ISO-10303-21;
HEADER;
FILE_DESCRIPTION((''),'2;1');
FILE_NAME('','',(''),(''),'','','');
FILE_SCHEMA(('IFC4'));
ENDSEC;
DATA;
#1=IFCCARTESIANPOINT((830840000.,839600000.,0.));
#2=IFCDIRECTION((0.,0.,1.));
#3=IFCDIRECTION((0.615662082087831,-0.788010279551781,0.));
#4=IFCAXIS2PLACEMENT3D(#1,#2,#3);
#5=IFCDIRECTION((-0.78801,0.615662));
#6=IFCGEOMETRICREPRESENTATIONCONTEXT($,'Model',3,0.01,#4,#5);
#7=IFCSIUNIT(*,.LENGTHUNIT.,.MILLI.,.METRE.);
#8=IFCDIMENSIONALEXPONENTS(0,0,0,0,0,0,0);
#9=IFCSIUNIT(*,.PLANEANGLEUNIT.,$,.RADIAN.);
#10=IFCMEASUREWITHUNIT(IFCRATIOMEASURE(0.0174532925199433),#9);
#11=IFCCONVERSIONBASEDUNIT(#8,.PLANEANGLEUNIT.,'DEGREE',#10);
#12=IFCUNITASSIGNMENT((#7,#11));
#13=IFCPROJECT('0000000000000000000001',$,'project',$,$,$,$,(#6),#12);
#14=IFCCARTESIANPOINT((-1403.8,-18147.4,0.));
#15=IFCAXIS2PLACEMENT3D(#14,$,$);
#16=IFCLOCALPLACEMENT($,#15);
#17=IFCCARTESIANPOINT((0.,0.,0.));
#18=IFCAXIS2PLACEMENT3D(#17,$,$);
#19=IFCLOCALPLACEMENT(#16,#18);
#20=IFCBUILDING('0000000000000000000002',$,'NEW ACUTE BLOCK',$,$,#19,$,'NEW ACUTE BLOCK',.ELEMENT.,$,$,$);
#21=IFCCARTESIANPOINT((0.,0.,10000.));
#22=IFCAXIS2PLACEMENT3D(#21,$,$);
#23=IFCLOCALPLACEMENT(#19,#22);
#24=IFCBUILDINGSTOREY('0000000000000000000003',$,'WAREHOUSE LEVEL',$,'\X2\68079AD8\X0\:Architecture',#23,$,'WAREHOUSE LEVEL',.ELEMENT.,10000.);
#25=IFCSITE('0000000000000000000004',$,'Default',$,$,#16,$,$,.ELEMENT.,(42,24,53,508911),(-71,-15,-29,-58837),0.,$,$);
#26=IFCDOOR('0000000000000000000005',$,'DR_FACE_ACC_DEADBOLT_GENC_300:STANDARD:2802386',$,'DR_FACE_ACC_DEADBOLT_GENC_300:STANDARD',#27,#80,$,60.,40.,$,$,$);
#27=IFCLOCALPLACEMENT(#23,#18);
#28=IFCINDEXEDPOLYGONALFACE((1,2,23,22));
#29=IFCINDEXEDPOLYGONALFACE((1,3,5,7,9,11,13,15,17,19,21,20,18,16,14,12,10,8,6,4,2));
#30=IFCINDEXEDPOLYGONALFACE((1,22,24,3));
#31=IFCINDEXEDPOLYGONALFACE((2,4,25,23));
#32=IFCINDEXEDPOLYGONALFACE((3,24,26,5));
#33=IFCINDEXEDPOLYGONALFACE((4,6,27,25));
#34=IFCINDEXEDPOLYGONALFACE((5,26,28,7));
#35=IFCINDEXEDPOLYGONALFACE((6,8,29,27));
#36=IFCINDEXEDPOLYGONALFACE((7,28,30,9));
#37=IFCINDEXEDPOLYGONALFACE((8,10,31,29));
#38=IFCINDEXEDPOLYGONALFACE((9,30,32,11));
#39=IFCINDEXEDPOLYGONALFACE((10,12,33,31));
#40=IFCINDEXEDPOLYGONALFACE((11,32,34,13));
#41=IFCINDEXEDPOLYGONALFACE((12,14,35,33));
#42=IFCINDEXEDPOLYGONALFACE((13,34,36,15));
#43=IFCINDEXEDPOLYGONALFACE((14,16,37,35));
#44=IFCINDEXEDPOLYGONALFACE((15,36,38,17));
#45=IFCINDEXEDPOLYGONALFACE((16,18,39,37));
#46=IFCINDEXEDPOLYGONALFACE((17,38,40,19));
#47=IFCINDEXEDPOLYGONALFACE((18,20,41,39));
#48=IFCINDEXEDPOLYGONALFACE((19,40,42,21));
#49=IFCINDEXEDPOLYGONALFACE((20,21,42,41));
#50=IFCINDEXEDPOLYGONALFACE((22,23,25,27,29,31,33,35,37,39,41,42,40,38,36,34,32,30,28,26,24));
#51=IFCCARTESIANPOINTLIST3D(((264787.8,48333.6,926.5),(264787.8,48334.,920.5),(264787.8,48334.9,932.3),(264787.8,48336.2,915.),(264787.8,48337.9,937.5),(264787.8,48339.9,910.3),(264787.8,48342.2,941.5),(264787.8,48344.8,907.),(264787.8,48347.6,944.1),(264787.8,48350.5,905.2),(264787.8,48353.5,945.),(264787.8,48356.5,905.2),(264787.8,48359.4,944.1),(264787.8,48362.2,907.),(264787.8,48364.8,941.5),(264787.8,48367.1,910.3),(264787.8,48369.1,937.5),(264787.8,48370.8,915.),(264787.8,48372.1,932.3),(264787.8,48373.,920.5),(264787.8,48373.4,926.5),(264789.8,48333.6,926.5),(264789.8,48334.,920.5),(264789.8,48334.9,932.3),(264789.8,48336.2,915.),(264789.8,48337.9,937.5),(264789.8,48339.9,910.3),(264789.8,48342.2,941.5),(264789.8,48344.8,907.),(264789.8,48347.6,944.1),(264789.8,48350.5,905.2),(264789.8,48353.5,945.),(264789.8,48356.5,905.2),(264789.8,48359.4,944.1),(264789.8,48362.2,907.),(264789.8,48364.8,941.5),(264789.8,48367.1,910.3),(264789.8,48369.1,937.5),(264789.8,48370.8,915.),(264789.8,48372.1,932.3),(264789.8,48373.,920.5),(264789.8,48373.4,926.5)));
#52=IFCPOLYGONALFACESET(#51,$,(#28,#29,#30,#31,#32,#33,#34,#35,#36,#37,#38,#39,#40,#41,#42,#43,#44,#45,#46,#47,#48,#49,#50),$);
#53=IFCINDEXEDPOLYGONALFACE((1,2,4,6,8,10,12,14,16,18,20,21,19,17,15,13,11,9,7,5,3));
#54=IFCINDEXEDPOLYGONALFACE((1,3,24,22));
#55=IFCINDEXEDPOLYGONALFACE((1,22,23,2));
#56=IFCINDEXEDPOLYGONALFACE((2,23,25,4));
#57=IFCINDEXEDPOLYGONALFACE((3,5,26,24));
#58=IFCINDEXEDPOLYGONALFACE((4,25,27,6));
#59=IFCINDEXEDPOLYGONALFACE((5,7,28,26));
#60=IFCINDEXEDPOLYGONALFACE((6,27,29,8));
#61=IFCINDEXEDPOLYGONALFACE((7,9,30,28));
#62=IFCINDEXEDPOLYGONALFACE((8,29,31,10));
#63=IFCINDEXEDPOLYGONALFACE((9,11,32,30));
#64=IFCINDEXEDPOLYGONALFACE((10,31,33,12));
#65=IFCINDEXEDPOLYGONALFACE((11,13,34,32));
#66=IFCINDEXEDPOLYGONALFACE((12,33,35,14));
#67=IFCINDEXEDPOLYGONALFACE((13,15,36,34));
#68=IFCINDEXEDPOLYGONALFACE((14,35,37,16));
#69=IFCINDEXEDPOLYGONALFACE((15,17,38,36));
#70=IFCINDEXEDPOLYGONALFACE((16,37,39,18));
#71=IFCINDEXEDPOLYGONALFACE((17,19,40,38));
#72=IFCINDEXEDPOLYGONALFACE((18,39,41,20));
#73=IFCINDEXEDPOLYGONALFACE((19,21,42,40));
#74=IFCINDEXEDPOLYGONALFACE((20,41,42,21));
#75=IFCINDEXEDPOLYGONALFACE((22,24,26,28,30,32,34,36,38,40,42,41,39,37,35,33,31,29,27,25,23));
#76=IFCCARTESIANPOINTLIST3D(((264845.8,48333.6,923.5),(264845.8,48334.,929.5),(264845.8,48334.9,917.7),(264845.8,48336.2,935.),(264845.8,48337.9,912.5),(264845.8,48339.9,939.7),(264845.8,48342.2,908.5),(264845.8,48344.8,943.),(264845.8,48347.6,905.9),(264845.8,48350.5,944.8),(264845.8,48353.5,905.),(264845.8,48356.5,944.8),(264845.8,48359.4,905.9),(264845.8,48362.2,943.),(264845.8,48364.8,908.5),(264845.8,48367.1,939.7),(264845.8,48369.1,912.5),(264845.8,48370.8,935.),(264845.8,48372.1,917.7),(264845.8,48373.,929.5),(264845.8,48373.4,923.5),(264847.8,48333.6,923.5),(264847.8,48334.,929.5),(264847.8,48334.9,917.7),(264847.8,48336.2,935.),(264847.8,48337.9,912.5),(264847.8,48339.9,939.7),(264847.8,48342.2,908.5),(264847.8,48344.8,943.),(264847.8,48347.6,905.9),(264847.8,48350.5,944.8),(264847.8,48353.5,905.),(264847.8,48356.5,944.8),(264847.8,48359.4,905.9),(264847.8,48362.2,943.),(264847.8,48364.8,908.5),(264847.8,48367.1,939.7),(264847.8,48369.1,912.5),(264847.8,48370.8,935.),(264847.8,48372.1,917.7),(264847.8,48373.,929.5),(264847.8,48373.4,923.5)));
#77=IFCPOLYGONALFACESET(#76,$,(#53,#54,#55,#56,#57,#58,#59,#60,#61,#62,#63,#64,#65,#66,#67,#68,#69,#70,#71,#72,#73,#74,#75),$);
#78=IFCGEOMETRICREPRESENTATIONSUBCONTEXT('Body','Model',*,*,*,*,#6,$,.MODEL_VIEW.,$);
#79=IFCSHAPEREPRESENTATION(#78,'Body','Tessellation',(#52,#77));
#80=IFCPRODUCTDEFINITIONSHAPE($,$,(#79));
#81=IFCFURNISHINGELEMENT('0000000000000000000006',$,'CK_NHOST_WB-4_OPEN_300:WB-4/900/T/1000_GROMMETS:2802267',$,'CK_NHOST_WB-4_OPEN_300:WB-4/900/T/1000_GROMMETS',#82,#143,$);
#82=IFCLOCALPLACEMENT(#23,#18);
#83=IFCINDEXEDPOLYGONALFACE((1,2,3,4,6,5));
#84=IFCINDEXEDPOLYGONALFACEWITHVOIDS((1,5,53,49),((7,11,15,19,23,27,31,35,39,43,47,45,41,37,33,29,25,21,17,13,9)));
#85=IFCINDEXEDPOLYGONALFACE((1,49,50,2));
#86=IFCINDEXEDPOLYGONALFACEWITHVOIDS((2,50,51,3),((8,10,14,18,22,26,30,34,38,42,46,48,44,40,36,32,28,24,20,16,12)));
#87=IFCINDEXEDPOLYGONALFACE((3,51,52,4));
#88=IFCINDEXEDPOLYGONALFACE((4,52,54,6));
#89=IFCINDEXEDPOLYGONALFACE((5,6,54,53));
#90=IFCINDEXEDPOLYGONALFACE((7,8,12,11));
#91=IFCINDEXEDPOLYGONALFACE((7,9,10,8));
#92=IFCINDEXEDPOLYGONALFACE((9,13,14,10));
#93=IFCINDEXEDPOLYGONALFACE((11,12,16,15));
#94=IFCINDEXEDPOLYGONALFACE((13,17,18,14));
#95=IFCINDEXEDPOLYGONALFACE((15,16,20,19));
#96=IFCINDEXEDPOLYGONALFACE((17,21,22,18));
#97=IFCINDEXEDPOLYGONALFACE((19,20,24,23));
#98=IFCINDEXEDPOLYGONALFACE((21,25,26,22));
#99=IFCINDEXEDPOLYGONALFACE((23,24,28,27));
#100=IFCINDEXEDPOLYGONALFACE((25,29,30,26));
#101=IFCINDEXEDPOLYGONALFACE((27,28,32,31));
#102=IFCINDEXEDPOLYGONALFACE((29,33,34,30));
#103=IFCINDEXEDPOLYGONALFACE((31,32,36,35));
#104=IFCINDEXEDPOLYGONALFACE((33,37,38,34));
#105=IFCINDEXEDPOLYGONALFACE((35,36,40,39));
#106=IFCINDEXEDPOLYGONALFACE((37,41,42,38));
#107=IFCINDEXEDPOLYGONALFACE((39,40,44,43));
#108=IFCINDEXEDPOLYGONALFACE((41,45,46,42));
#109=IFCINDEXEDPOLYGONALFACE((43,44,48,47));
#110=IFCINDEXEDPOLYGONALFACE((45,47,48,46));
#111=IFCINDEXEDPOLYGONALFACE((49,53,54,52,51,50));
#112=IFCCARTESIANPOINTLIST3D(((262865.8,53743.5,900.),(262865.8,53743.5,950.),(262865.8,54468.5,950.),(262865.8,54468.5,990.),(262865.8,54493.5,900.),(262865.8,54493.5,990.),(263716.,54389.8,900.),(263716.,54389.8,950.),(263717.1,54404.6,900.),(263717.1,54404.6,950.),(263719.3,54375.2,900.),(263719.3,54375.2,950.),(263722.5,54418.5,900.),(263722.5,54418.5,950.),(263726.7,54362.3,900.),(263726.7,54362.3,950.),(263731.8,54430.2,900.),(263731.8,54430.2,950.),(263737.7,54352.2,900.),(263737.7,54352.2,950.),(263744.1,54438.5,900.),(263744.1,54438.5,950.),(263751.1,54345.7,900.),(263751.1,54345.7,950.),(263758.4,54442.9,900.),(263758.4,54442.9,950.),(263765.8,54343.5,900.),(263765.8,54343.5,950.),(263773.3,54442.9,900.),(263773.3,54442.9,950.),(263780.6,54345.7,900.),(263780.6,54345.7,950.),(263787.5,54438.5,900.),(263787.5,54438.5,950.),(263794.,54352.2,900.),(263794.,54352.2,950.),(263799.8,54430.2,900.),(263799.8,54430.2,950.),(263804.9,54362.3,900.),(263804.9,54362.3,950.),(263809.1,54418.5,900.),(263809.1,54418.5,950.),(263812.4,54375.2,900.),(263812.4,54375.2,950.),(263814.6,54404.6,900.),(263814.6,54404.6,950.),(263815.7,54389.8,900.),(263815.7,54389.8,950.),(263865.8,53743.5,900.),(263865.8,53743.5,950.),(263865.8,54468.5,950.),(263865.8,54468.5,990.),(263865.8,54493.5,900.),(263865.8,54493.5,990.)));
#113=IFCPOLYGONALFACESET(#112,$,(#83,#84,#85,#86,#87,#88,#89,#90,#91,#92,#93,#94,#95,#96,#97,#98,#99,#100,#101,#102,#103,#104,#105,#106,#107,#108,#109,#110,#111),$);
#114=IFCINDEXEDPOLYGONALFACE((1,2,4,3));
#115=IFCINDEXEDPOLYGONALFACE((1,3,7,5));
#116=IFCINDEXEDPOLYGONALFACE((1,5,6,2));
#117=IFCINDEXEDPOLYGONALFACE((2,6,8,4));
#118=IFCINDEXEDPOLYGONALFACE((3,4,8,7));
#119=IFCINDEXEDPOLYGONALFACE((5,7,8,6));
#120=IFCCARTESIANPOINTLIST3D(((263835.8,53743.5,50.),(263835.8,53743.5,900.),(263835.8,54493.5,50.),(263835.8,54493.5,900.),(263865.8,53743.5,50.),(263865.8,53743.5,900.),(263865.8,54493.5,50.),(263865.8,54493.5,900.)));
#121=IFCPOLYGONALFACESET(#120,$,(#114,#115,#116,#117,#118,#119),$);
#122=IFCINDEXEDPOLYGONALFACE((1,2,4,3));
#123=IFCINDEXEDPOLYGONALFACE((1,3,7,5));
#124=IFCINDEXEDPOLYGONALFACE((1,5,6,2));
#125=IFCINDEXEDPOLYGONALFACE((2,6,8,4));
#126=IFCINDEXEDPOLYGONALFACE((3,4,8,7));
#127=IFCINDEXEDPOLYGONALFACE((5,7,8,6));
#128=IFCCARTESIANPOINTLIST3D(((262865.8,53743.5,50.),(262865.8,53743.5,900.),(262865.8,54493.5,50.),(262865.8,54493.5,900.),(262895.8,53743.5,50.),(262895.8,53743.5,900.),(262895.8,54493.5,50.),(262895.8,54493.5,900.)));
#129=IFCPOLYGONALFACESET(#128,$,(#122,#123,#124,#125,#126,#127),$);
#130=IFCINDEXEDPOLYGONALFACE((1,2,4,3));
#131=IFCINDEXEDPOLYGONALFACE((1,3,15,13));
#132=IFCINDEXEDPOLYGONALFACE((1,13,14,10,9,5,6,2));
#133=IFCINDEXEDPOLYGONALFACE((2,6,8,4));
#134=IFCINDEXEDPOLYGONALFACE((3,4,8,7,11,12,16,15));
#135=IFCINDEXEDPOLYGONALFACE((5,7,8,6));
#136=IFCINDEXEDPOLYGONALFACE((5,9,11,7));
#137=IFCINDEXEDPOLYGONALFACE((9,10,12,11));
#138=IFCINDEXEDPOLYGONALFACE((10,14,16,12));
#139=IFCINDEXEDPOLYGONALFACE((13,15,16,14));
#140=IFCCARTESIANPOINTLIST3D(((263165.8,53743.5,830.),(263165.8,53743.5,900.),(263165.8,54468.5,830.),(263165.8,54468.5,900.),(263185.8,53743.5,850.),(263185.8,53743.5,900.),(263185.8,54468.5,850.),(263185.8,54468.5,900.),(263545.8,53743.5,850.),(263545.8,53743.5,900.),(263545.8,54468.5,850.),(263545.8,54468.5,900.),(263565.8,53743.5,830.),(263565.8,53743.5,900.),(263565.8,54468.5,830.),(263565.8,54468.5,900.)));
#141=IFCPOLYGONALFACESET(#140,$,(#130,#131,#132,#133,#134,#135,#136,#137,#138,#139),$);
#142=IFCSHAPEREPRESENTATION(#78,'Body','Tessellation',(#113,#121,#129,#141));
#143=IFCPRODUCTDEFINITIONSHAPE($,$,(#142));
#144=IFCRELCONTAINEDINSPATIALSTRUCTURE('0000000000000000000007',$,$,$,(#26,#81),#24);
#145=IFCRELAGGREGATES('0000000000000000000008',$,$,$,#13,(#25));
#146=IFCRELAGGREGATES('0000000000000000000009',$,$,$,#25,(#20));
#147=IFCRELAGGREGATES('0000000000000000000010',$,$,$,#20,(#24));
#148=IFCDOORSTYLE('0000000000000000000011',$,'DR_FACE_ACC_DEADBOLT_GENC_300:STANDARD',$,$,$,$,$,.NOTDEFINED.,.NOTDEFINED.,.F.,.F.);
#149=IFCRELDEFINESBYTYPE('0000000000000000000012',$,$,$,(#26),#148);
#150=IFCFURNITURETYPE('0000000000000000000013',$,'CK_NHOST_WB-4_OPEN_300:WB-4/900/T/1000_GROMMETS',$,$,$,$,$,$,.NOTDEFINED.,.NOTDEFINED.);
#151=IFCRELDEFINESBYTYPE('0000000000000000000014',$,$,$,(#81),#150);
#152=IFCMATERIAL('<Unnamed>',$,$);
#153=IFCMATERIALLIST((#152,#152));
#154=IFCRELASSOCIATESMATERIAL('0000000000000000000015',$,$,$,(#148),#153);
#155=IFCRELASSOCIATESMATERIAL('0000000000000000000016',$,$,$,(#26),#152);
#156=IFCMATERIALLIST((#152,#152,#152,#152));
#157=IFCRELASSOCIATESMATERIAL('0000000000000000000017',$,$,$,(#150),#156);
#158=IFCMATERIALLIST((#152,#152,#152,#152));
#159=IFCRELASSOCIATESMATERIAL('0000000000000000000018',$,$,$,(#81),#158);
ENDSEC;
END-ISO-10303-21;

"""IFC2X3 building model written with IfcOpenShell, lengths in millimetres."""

from ifc_helpers import new_model, entity, si_unit, converted_unit, direction, frame, frame_2d, origin, place, context, subcontext, project, spatial, polyline, rectangle, circle, outline, extrude, source, transform, mapped, material, material_list, type_object, type_shapes, element, save


model = new_model("IFC2X3")

# Units and contexts
model_context = context("Model", 3, precision=0.01, world=frame((830840000.0, 839600000.0, 0.0), z_axis=(0.0, 0.0, 1.0), x_axis=(0.615662082087831, -0.788010279551781, 0.0)), true_north=direction((-0.78801, 0.615662)))
body_context = subcontext(model_context, "Body", "Model", "MODEL_VIEW")
ifc_project = project(units=[si_unit("LENGTHUNIT", "METRE", prefix="MILLI"), converted_unit("PLANEANGLEUNIT", "DEGREE", entity("IfcRatioMeasure", 0.0174532925199433), si_unit("PLANEANGLEUNIT", "RADIAN"), dimensions=[0, 0, 0, 0, 0, 0, 0])], contexts=[model_context])

# Site, building, storey
site_placement = place(None, frame((-1403.8, -18147.4, 0.0)))
site = spatial("IfcSite", under=ifc_project, at=site_placement, Name="Default", CompositionType="ELEMENT", RefLatitude=(42, 24, 53, 508911), RefLongitude=(-71, -15, -29, -58837), RefElevation=0.0)
building_placement = place(site_placement, origin())
building = spatial("IfcBuilding", under=site, at=building_placement, Name="NEW ACUTE BLOCK", LongName="NEW ACUTE BLOCK", CompositionType="ELEMENT")
storey_placement = place(building_placement, frame((0.0, 0.0, 10000.0)))
storey = spatial("IfcBuildingStorey", under=building, at=storey_placement, Name="WAREHOUSE LEVEL", ObjectType="标高:Architecture", LongName="WAREHOUSE LEVEL", CompositionType="ELEMENT", Elevation=10000.0)

# Door
ifc_material_1 = material(Name="<Unnamed>")
ifc_material_list_1 = material_list([ifc_material_1, ifc_material_1])
door_style_1 = type_object("IfcDoorStyle", Name="DR_FACE_ACC_DEADBOLT_GENC_300:STANDARD", ConstructionType="NOTDEFINED", OperationType="NOTDEFINED", ParameterTakesPrecedence=False, Sizeable=False, material=ifc_material_list_1)
shared_shape_1 = source(origin(), body_context, "Body", "SweptSolid", [
    extrude(circle(Radius=20.0, at=frame_2d((0.0, 0.0), x_axis=(1.0, 0.0))), frame((0.0, 0.0, -58.0), z_axis=(0.0, 0.0, 1.0), x_axis=(-1.0, 0.0, 0.0)), (0.0, 0.0, 1.0), 2.0),
    extrude(circle(Radius=20.0, at=frame_2d((0.0, 0.0), x_axis=(1.0, 0.0))), origin(), (0.0, 0.0, 1.0), 2.0),
])
type_shapes(door_style_1, [shared_shape_1])
door_1_placement = place(storey_placement, frame((264845.8, 48353.5, 925.0), z_axis=(1.0, 0.0, 0.0), x_axis=(0.0, 0.0, -1.0)))
element("IfcDoor", 1, at=door_1_placement, inside=storey, type_object=door_style_1, material=ifc_material_1, Name="DR_FACE_ACC_DEADBOLT_GENC_300:STANDARD:2802386", ObjectType="DR_FACE_ACC_DEADBOLT_GENC_300:STANDARD", OverallHeight=60.0, OverallWidth=40.0, context=body_context, shape_type="MappedRepresentation", body=[
    mapped(shared_shape_1, transform((0.0, 0.0, 0.0), scale=1.0)),
])

# Furnishing element, opening
ifc_material_list_2 = material_list([ifc_material_1, ifc_material_1, ifc_material_1, ifc_material_1])
ifc_material_list_3 = material_list([ifc_material_1, ifc_material_1, ifc_material_1, ifc_material_1])
furniture_type_1 = type_object("IfcFurnitureType", Name="CK_NHOST_WB-4_OPEN_300:WB-4/900/T/1000_GROMMETS", material=ifc_material_list_3)
shared_shape_2 = source(origin(), body_context, "Body", "SweptSolid", [
    extrude(outline(polyline([(-46.7, -258.3), (43.3, -258.3), (43.3, -233.3), (3.3, -233.3), (3.3, 491.7), (-46.7, 491.7), (-46.7, -258.3)])), frame((-500.0, 116.7, 896.7), z_axis=(1.0, 0.0, 0.0), x_axis=(0.0, 0.0, 1.0)), (0.0, 0.0, 1.0), 1000.0),
    extrude(rectangle(XDim=750.0, YDim=30.0, at=frame_2d((0.0, 0.0), x_axis=(1.0, 0.0))), frame((485.0, 0.0, 0.0), z_axis=(0.0, 0.0, 1.0), x_axis=(0.0, -1.0, 0.0)), (0.0, 0.0, 1.0), 850.0),
    extrude(rectangle(XDim=30.0, YDim=750.0, at=frame_2d((0.0, 0.0), x_axis=(1.0, 0.0))), frame((-485.0, 0.0, 0.0), z_axis=(0.0, 0.0, 1.0), x_axis=(-1.0, 0.0, 0.0)), (0.0, 0.0, 1.0), 850.0),
    extrude(outline(polyline([(-40.0, -200.0), (30.0, -200.0), (30.0, -180.0), (-20.0, -180.0), (-20.0, 180.0), (30.0, 180.0), (30.0, 200.0), (-40.0, 200.0), (-40.0, -200.0)])), frame((0.0, -375.0, 820.0), z_axis=(0.0, 1.0, 0.0), x_axis=(0.0, 0.0, 1.0)), (0.0, 0.0, 1.0), 725.0),
])
type_shapes(furniture_type_1, [shared_shape_2])
furnishing_1_placement = place(storey_placement, frame((263365.8, 54118.5, 50.0)))
furnishing_1 = element("IfcFurnishingElement", 2, at=furnishing_1_placement, inside=storey, type_object=furniture_type_1, material=ifc_material_list_2, Name="CK_NHOST_WB-4_OPEN_300:WB-4/900/T/1000_GROMMETS:2802267", ObjectType="CK_NHOST_WB-4_OPEN_300:WB-4/900/T/1000_GROMMETS", context=body_context, shape_type="MappedRepresentation", body=[
    mapped(shared_shape_2, transform((0.0, 0.0, 0.0), scale=1.0)),
])
opening_1_placement = place(storey_placement, frame((263365.8, 54118.5, 10050.0)))
element("IfcOpeningElement", 3, at=opening_1_placement, cuts=furnishing_1, ObjectType="Opening", context=body_context, shape_type="SweptSolid", body=[
    extrude(circle(Radius=50.0, at=frame_2d((0.0, 0.0), x_axis=(1.0, 0.0))), frame((400.0, 275.0, -9150.0), z_axis=(0.0, 0.0, 1.0), x_axis=(0.0, -1.0, 0.0)), (0.0, 0.0, 1.0), 50.0),
])

save(model, "model.ifc")
